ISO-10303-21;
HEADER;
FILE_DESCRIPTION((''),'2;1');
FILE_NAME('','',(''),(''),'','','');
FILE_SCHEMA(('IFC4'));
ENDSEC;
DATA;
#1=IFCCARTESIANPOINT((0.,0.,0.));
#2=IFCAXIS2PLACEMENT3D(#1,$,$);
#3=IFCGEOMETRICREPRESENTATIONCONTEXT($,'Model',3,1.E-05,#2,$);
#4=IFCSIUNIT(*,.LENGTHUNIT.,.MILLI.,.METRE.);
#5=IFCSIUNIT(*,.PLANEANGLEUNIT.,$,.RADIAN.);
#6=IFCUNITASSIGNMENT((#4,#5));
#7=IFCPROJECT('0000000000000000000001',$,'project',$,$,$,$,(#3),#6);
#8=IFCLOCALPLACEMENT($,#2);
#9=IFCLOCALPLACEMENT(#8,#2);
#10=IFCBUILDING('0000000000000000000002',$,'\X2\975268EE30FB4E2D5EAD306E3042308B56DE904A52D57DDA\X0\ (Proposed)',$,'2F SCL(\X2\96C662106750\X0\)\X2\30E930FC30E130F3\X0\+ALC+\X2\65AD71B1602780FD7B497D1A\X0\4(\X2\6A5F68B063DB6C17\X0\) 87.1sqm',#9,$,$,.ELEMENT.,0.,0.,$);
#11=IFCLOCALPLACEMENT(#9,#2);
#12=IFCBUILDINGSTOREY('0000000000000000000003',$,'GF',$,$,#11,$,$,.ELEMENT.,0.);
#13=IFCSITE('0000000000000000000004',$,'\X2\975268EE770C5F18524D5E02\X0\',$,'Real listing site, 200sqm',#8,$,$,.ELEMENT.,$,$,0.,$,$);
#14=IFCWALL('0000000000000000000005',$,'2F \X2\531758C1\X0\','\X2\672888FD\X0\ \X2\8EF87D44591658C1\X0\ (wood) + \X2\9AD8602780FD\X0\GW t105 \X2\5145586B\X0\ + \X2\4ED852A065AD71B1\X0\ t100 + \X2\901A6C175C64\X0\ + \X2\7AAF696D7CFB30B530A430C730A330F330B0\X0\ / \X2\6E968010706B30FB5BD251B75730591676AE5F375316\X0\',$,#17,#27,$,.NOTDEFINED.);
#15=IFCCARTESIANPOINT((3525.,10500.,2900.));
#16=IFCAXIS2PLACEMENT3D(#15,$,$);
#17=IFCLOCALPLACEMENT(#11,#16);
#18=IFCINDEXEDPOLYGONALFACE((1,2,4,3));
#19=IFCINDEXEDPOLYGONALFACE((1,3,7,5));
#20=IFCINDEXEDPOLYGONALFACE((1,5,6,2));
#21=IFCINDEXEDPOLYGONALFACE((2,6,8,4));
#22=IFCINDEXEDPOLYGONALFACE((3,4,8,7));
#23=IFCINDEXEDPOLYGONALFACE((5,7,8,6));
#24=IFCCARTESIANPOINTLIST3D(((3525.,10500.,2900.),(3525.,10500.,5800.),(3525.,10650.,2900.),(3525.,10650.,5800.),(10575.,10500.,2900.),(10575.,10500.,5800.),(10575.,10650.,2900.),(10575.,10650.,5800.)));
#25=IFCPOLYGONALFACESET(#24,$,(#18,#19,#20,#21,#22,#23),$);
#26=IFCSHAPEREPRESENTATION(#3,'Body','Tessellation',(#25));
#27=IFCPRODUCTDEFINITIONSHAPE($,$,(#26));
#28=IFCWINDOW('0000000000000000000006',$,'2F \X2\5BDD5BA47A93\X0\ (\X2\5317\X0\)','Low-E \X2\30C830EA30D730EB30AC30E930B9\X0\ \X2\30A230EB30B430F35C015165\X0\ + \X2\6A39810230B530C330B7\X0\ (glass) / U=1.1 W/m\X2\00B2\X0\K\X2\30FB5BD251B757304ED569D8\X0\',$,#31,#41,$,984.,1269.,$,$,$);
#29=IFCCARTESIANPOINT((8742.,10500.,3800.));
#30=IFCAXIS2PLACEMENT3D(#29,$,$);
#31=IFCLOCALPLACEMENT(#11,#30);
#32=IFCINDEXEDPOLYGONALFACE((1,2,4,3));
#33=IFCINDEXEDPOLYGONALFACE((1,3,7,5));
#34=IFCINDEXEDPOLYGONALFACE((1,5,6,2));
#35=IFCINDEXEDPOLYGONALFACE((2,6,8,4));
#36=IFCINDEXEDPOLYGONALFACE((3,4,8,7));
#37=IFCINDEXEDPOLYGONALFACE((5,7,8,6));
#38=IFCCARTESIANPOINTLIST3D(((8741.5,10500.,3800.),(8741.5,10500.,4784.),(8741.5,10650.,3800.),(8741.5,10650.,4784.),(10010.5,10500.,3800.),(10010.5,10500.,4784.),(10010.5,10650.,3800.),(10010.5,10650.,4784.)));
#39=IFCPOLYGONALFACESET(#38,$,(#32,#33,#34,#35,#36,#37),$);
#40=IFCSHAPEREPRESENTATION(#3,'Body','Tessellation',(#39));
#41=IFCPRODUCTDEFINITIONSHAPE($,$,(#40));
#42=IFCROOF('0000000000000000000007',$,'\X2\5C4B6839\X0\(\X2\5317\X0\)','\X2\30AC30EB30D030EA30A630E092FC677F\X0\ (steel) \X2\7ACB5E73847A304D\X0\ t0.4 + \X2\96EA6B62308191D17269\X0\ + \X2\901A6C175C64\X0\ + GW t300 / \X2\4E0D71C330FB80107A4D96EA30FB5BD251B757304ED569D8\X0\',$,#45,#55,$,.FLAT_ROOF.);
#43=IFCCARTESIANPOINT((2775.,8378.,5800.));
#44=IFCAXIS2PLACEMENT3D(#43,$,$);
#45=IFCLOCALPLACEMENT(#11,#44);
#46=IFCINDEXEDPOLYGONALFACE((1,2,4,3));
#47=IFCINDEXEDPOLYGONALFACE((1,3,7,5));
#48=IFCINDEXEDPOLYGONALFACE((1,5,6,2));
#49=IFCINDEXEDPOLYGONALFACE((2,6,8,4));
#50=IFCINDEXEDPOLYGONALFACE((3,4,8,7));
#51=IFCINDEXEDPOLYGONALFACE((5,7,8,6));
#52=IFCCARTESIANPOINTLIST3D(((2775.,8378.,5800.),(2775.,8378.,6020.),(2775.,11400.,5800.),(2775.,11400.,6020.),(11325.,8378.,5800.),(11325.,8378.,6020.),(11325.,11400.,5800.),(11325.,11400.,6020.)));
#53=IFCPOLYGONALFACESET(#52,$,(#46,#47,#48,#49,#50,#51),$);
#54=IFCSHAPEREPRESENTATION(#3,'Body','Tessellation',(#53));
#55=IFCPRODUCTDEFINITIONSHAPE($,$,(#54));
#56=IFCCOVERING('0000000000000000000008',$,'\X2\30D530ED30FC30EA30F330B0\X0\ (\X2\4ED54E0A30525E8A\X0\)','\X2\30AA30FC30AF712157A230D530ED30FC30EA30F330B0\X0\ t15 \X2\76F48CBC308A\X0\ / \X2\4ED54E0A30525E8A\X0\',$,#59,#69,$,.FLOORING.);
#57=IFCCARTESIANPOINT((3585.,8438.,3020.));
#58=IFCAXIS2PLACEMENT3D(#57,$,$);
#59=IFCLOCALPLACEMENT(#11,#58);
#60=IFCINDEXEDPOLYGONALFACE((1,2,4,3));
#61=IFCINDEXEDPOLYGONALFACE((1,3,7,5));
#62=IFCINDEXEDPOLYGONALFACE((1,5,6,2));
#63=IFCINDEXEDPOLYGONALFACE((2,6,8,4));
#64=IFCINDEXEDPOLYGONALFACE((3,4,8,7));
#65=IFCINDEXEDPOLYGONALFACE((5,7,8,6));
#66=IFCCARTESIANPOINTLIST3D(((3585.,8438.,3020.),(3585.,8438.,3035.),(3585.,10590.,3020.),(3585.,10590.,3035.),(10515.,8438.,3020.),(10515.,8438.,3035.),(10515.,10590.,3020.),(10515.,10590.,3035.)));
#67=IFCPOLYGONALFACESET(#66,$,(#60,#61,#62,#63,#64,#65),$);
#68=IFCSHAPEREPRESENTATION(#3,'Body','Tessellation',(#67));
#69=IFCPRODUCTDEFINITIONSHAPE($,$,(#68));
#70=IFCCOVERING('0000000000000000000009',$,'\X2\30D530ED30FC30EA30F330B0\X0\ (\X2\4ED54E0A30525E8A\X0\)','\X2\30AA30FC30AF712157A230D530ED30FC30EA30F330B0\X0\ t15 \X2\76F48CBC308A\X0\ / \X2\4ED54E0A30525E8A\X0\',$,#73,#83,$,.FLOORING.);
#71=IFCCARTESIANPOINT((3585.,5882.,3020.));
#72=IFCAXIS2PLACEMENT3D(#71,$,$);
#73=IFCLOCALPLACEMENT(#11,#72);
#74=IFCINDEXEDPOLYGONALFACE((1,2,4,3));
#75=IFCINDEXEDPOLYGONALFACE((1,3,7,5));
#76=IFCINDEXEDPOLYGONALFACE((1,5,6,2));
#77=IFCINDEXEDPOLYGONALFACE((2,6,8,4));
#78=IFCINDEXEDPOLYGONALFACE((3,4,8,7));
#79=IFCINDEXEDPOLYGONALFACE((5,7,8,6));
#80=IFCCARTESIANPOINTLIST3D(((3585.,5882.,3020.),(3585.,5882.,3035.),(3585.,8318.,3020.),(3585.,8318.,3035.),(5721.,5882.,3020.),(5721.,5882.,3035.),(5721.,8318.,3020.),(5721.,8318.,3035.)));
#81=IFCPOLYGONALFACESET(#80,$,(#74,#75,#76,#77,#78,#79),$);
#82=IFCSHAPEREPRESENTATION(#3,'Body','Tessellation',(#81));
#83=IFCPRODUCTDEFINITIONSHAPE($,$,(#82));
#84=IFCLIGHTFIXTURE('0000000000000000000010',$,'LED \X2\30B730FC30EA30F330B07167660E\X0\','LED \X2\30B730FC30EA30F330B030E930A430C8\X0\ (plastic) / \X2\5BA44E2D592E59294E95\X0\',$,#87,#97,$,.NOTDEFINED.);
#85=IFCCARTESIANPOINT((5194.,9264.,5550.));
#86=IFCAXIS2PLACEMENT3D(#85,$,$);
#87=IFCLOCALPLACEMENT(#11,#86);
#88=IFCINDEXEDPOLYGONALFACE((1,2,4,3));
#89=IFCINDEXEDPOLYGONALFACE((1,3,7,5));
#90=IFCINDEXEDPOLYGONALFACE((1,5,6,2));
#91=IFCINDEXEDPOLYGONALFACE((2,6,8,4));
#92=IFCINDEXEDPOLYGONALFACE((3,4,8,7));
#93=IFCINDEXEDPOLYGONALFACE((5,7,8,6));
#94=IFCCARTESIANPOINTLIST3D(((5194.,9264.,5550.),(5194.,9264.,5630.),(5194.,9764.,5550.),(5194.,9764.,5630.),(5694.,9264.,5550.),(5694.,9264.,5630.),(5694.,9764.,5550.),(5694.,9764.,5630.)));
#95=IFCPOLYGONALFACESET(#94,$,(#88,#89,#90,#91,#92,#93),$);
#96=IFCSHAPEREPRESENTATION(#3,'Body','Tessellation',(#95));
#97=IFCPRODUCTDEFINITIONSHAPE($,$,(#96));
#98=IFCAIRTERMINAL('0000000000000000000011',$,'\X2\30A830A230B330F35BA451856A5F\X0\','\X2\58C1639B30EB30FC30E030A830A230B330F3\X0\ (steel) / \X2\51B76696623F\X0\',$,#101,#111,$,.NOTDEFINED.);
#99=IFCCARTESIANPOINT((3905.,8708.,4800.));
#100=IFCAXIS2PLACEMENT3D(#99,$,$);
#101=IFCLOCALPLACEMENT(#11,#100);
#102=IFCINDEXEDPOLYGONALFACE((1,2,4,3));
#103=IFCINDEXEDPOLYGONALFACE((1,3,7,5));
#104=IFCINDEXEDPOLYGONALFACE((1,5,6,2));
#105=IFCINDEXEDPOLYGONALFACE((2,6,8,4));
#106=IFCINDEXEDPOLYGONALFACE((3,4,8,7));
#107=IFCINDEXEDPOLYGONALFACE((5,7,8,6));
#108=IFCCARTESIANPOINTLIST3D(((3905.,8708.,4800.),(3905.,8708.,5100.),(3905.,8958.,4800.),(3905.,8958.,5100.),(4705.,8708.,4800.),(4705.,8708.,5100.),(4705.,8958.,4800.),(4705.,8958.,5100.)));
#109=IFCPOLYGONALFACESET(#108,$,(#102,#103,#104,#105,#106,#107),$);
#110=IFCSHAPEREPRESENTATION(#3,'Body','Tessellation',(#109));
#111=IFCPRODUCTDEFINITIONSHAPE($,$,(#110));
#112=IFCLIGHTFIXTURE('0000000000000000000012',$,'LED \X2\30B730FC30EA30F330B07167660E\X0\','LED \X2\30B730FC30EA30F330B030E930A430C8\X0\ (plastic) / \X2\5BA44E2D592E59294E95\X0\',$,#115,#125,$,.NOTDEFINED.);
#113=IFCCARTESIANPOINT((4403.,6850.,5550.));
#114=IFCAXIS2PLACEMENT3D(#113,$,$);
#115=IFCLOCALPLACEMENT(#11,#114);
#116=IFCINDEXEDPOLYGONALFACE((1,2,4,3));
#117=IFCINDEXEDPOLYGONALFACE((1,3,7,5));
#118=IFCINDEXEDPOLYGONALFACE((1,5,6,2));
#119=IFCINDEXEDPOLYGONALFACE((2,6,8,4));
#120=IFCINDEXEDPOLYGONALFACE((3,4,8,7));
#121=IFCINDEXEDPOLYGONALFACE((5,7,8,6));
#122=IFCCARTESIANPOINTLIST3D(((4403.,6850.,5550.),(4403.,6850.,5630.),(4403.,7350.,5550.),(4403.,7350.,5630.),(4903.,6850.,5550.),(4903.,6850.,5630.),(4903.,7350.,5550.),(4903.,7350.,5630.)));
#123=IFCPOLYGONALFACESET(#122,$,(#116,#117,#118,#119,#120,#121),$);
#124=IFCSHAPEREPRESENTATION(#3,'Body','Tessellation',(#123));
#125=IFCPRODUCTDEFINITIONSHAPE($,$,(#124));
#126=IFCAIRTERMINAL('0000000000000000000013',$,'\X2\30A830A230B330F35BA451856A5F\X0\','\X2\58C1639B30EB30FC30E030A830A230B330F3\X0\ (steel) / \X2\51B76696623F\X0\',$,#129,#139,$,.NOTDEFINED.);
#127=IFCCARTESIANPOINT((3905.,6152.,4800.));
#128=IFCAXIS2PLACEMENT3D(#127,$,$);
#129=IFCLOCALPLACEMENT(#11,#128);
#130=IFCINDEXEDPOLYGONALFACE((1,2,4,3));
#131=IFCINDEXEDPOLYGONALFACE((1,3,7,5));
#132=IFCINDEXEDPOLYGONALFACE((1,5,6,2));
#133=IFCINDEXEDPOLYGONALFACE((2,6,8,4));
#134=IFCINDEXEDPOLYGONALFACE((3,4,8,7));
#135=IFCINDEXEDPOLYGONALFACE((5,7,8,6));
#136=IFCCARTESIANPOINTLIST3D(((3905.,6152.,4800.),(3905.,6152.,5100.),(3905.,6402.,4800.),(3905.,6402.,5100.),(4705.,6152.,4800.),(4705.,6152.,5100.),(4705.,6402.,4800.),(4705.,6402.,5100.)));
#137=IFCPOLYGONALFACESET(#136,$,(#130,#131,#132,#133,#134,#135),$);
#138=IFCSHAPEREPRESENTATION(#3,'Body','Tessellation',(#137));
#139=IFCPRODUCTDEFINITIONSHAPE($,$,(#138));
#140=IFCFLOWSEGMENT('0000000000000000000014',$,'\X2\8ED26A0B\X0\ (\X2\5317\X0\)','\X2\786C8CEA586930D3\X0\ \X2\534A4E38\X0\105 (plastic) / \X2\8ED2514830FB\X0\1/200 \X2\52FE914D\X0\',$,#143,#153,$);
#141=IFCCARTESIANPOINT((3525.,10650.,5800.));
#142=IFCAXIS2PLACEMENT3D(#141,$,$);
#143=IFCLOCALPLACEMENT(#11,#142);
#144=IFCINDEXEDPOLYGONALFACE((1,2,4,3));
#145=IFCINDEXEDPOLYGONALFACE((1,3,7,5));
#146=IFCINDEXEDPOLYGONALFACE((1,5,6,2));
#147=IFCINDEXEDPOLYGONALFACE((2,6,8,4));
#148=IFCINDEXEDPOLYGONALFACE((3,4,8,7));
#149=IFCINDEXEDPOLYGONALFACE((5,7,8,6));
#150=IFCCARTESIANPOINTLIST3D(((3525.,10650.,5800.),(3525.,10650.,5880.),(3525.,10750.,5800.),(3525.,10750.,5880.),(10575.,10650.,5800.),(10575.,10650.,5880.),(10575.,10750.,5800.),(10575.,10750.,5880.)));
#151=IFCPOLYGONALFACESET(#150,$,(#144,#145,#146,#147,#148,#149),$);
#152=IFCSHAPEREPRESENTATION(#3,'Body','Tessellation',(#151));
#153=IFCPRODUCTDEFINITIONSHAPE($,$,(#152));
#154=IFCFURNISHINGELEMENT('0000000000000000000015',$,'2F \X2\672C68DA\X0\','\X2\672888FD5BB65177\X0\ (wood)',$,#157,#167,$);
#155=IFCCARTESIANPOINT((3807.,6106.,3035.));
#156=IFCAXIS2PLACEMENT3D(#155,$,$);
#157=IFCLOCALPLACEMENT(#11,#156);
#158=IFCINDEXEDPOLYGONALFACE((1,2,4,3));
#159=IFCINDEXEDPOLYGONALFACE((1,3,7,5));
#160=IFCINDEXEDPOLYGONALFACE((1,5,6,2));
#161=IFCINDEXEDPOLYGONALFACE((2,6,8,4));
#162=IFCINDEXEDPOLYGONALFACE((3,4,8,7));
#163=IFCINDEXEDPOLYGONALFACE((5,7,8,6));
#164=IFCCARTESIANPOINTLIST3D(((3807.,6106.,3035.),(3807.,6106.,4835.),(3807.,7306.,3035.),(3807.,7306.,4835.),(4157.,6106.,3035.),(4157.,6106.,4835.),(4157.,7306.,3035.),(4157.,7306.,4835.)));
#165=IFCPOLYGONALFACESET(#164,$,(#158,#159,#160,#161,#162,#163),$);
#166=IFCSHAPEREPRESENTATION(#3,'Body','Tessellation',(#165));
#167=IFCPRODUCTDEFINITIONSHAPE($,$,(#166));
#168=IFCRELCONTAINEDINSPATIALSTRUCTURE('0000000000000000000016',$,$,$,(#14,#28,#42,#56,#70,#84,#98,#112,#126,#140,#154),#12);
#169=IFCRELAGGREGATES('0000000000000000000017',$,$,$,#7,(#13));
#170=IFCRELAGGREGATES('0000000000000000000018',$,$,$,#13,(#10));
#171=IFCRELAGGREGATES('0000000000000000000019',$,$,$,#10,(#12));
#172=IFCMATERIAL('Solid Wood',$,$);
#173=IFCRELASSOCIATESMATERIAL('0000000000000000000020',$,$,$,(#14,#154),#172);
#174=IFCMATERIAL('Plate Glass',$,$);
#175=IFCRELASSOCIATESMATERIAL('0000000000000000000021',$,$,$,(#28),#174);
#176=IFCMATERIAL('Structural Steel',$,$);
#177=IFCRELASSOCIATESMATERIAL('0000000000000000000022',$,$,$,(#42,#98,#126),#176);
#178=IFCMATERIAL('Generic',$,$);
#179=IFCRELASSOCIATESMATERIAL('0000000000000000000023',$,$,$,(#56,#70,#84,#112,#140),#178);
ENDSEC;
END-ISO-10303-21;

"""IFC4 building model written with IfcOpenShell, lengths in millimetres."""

from ifc_helpers import new_model, si_unit, frame, frame_2d, origin, place, context, project, spatial, rectangle, extrude, material, element, fill, save


model = new_model("IFC4")

# Units and contexts
model_context = context("Model", 3, precision=1e-05, world=origin())
ifc_project = project(units=[si_unit("LENGTHUNIT", "METRE", prefix="MILLI"), si_unit("PLANEANGLEUNIT", "RADIAN")], contexts=[model_context])

# Site, building, storey
site_placement = place(None, origin())
site = spatial("IfcSite", under=ifc_project, at=site_placement, Name="青森県弘前市", ObjectType="Real listing site, 200sqm", CompositionType="ELEMENT", RefElevation=0.0)
building_placement = place(site_placement, origin())
building = spatial("IfcBuilding", under=site, at=building_placement, Name="青森・中庭のある回遊動線 (Proposed)", ObjectType="2F SCL(集成材)ラーメン+ALC+断熱性能等級4(機械換気) 87.1sqm", CompositionType="ELEMENT", ElevationOfRefHeight=0.0, ElevationOfTerrain=0.0)
storey_placement = place(building_placement, origin())
storey = spatial("IfcBuildingStorey", under=building, at=storey_placement, Name="GF", CompositionType="ELEMENT", Elevation=0.0)

# Shared definitions
ifc_material_1 = material(Name="Solid Wood")

# Wall, opening, window
wall_placement = place(storey_placement, frame((3525.0, 10500.0, 2900.0)))
wall = element("IfcWall", 1, at=wall_placement, inside=storey, material=ifc_material_1, Name="2F 北壁", Description="木製 軸組外壁 (wood) + 高性能GW t105 充填 + 付加断熱 t100 + 通気層 + 窯業系サイディング / 準耐火・寒冷地外皮強化", PredefinedType="NOTDEFINED", context=model_context, shape_type="SweptSolid", body=[
    extrude(rectangle(XDim=7050.0, YDim=150.0, at=frame_2d((3525.0, 75.0))), frame((3525.0, 10500.0, 2900.0)), (0.0, 0.0, 1.0), 2900.0),
])
opening_placement = place(storey_placement, frame((8742.0, 10500.0, 3800.0)))
opening = element("IfcOpeningElement", 2, at=opening_placement, cuts=wall, PredefinedType="NOTDEFINED", context=model_context, shape_type="SweptSolid", body=[
    extrude(rectangle(XDim=1269.0, YDim=150.0, at=frame_2d((634.0, 75.0))), frame((8742.0, 10500.0, 3800.0)), (0.0, 0.0, 1.0), 984.0),
])
ifc_material_2 = material(Name="Plate Glass")
window_placement = place(storey_placement, frame((8742.0, 10500.0, 3800.0)))
window = element("IfcWindow", 3, at=window_placement, inside=storey, material=ifc_material_2, Name="2F 寝室窓 (北)", Description="Low-E トリプルガラス アルゴン封入 + 樹脂サッシ (glass) / U=1.1 W/m²K・寒冷地仕様", OverallHeight=984.0, OverallWidth=1269.0, context=model_context, shape_type="SweptSolid", body=[
    extrude(rectangle(XDim=1269.0, YDim=150.0, at=frame_2d((634.0, 75.0))), frame((8742.0, 10500.0, 3800.0)), (0.0, 0.0, 1.0), 984.0),
])
fill(opening, window)

# Roof
ifc_material_3 = material(Name="Structural Steel")
for number, where, name in (
    (4, (2775.0, 8378.0, 5800.0), "屋根(北)"),
):
    element("IfcRoof", number, at=place(storey_placement, frame(where)), inside=storey, material=ifc_material_3, Name=name, Description="ガルバリウム鋼板 (steel) 立平葺き t0.4 + 雪止め金物 + 通気層 + GW t300 / 不燃・耐積雪・寒冷地仕様", PredefinedType="FLAT_ROOF", context=model_context, shape_type="SweptSolid", body=[
        extrude(rectangle(XDim=8550.0, YDim=3022.0, at=frame_2d((4275.0, 1511.0))), frame((2775.0, 8378.0, 5800.0)), (0.0, 0.0, 1.0), 220.0),
    ])

# Coverings
ifc_material_4 = material(Name="Generic")
covering_1_placement = place(storey_placement, frame((3585.0, 8438.0, 3020.0)))
element("IfcCovering", 5, at=covering_1_placement, inside=storey, material=ifc_material_4, Name="フローリング (仕上げ床)", Description="オーク無垢フローリング t15 直貼り / 仕上げ床", PredefinedType="FLOORING", context=model_context, shape_type="SweptSolid", body=[
    extrude(rectangle(XDim=6930.0, YDim=2152.0, at=frame_2d((3465.0, 1076.0))), frame((3585.0, 8438.0, 3020.0)), (0.0, 0.0, 1.0), 15.0),
])
covering_2_placement = place(storey_placement, frame((3585.0, 5882.0, 3020.0)))
element("IfcCovering", 6, at=covering_2_placement, inside=storey, material=ifc_material_4, Name="フローリング (仕上げ床)", Description="オーク無垢フローリング t15 直貼り / 仕上げ床", PredefinedType="FLOORING", context=model_context, shape_type="SweptSolid", body=[
    extrude(rectangle(XDim=2136.0, YDim=2436.0, at=frame_2d((1068.0, 1218.0))), frame((3585.0, 5882.0, 3020.0)), (0.0, 0.0, 1.0), 15.0),
])

# Light fixture
light_fixture_1_placement = place(storey_placement, frame((5194.0, 9264.0, 5550.0)))
element("IfcLightFixture", 7, at=light_fixture_1_placement, inside=storey, material=ifc_material_4, Name="LED シーリング照明", Description="LED シーリングライト (plastic) / 室中央天井", PredefinedType="NOTDEFINED", context=model_context, shape_type="SweptSolid", body=[
    extrude(rectangle(XDim=500.0, YDim=500.0, at=frame_2d((250.0, 250.0))), frame((5194.0, 9264.0, 5550.0)), (0.0, 0.0, 1.0), 80.0),
])

# Air terminal
air_terminal_1_placement = place(storey_placement, frame((3905.0, 8708.0, 4800.0)))
element("IfcAirTerminal", 8, at=air_terminal_1_placement, inside=storey, material=ifc_material_3, Name="エアコン室内機", Description="壁掛ルームエアコン (steel) / 冷暖房", PredefinedType="NOTDEFINED", context=model_context, shape_type="SweptSolid", body=[
    extrude(rectangle(XDim=800.0, YDim=250.0, at=frame_2d((400.0, 125.0))), frame((3905.0, 8708.0, 4800.0)), (0.0, 0.0, 1.0), 300.0),
])

# Light fixture
light_fixture_2_placement = place(storey_placement, frame((4403.0, 6850.0, 5550.0)))
element("IfcLightFixture", 9, at=light_fixture_2_placement, inside=storey, material=ifc_material_4, Name="LED シーリング照明", Description="LED シーリングライト (plastic) / 室中央天井", PredefinedType="NOTDEFINED", context=model_context, shape_type="SweptSolid", body=[
    extrude(rectangle(XDim=500.0, YDim=500.0, at=frame_2d((250.0, 250.0))), frame((4403.0, 6850.0, 5550.0)), (0.0, 0.0, 1.0), 80.0),
])

# Air terminal
air_terminal_2_placement = place(storey_placement, frame((3905.0, 6152.0, 4800.0)))
element("IfcAirTerminal", 10, at=air_terminal_2_placement, inside=storey, material=ifc_material_3, Name="エアコン室内機", Description="壁掛ルームエアコン (steel) / 冷暖房", PredefinedType="NOTDEFINED", context=model_context, shape_type="SweptSolid", body=[
    extrude(rectangle(XDim=800.0, YDim=250.0, at=frame_2d((400.0, 125.0))), frame((3905.0, 6152.0, 4800.0)), (0.0, 0.0, 1.0), 300.0),
])

# Flow segment
flow_segment_placement = place(storey_placement, frame((3525.0, 10650.0, 5800.0)))
element("IfcFlowSegment", 11, at=flow_segment_placement, inside=storey, material=ifc_material_4, Name="軒樋 (北)", Description="硬質塩ビ 半丸105 (plastic) / 軒先・1/200 勾配", context=model_context, shape_type="SweptSolid", body=[
    extrude(rectangle(XDim=7050.0, YDim=100.0, at=frame_2d((3525.0, 50.0))), frame((3525.0, 10650.0, 5800.0)), (0.0, 0.0, 1.0), 80.0),
])

# Furnishing element
furnishing_placement = place(storey_placement, frame((3807.0, 6106.0, 3035.0)))
element("IfcFurnishingElement", 12, at=furnishing_placement, inside=storey, material=ifc_material_1, Name="2F 本棚", Description="木製家具 (wood)", context=model_context, shape_type="SweptSolid", body=[
    extrude(rectangle(XDim=350.0, YDim=1200.0, at=frame_2d((175.0, 600.0))), frame((3807.0, 6106.0, 3035.0)), (0.0, 0.0, 1.0), 1800.0),
])

save(model, "model.ifc")
